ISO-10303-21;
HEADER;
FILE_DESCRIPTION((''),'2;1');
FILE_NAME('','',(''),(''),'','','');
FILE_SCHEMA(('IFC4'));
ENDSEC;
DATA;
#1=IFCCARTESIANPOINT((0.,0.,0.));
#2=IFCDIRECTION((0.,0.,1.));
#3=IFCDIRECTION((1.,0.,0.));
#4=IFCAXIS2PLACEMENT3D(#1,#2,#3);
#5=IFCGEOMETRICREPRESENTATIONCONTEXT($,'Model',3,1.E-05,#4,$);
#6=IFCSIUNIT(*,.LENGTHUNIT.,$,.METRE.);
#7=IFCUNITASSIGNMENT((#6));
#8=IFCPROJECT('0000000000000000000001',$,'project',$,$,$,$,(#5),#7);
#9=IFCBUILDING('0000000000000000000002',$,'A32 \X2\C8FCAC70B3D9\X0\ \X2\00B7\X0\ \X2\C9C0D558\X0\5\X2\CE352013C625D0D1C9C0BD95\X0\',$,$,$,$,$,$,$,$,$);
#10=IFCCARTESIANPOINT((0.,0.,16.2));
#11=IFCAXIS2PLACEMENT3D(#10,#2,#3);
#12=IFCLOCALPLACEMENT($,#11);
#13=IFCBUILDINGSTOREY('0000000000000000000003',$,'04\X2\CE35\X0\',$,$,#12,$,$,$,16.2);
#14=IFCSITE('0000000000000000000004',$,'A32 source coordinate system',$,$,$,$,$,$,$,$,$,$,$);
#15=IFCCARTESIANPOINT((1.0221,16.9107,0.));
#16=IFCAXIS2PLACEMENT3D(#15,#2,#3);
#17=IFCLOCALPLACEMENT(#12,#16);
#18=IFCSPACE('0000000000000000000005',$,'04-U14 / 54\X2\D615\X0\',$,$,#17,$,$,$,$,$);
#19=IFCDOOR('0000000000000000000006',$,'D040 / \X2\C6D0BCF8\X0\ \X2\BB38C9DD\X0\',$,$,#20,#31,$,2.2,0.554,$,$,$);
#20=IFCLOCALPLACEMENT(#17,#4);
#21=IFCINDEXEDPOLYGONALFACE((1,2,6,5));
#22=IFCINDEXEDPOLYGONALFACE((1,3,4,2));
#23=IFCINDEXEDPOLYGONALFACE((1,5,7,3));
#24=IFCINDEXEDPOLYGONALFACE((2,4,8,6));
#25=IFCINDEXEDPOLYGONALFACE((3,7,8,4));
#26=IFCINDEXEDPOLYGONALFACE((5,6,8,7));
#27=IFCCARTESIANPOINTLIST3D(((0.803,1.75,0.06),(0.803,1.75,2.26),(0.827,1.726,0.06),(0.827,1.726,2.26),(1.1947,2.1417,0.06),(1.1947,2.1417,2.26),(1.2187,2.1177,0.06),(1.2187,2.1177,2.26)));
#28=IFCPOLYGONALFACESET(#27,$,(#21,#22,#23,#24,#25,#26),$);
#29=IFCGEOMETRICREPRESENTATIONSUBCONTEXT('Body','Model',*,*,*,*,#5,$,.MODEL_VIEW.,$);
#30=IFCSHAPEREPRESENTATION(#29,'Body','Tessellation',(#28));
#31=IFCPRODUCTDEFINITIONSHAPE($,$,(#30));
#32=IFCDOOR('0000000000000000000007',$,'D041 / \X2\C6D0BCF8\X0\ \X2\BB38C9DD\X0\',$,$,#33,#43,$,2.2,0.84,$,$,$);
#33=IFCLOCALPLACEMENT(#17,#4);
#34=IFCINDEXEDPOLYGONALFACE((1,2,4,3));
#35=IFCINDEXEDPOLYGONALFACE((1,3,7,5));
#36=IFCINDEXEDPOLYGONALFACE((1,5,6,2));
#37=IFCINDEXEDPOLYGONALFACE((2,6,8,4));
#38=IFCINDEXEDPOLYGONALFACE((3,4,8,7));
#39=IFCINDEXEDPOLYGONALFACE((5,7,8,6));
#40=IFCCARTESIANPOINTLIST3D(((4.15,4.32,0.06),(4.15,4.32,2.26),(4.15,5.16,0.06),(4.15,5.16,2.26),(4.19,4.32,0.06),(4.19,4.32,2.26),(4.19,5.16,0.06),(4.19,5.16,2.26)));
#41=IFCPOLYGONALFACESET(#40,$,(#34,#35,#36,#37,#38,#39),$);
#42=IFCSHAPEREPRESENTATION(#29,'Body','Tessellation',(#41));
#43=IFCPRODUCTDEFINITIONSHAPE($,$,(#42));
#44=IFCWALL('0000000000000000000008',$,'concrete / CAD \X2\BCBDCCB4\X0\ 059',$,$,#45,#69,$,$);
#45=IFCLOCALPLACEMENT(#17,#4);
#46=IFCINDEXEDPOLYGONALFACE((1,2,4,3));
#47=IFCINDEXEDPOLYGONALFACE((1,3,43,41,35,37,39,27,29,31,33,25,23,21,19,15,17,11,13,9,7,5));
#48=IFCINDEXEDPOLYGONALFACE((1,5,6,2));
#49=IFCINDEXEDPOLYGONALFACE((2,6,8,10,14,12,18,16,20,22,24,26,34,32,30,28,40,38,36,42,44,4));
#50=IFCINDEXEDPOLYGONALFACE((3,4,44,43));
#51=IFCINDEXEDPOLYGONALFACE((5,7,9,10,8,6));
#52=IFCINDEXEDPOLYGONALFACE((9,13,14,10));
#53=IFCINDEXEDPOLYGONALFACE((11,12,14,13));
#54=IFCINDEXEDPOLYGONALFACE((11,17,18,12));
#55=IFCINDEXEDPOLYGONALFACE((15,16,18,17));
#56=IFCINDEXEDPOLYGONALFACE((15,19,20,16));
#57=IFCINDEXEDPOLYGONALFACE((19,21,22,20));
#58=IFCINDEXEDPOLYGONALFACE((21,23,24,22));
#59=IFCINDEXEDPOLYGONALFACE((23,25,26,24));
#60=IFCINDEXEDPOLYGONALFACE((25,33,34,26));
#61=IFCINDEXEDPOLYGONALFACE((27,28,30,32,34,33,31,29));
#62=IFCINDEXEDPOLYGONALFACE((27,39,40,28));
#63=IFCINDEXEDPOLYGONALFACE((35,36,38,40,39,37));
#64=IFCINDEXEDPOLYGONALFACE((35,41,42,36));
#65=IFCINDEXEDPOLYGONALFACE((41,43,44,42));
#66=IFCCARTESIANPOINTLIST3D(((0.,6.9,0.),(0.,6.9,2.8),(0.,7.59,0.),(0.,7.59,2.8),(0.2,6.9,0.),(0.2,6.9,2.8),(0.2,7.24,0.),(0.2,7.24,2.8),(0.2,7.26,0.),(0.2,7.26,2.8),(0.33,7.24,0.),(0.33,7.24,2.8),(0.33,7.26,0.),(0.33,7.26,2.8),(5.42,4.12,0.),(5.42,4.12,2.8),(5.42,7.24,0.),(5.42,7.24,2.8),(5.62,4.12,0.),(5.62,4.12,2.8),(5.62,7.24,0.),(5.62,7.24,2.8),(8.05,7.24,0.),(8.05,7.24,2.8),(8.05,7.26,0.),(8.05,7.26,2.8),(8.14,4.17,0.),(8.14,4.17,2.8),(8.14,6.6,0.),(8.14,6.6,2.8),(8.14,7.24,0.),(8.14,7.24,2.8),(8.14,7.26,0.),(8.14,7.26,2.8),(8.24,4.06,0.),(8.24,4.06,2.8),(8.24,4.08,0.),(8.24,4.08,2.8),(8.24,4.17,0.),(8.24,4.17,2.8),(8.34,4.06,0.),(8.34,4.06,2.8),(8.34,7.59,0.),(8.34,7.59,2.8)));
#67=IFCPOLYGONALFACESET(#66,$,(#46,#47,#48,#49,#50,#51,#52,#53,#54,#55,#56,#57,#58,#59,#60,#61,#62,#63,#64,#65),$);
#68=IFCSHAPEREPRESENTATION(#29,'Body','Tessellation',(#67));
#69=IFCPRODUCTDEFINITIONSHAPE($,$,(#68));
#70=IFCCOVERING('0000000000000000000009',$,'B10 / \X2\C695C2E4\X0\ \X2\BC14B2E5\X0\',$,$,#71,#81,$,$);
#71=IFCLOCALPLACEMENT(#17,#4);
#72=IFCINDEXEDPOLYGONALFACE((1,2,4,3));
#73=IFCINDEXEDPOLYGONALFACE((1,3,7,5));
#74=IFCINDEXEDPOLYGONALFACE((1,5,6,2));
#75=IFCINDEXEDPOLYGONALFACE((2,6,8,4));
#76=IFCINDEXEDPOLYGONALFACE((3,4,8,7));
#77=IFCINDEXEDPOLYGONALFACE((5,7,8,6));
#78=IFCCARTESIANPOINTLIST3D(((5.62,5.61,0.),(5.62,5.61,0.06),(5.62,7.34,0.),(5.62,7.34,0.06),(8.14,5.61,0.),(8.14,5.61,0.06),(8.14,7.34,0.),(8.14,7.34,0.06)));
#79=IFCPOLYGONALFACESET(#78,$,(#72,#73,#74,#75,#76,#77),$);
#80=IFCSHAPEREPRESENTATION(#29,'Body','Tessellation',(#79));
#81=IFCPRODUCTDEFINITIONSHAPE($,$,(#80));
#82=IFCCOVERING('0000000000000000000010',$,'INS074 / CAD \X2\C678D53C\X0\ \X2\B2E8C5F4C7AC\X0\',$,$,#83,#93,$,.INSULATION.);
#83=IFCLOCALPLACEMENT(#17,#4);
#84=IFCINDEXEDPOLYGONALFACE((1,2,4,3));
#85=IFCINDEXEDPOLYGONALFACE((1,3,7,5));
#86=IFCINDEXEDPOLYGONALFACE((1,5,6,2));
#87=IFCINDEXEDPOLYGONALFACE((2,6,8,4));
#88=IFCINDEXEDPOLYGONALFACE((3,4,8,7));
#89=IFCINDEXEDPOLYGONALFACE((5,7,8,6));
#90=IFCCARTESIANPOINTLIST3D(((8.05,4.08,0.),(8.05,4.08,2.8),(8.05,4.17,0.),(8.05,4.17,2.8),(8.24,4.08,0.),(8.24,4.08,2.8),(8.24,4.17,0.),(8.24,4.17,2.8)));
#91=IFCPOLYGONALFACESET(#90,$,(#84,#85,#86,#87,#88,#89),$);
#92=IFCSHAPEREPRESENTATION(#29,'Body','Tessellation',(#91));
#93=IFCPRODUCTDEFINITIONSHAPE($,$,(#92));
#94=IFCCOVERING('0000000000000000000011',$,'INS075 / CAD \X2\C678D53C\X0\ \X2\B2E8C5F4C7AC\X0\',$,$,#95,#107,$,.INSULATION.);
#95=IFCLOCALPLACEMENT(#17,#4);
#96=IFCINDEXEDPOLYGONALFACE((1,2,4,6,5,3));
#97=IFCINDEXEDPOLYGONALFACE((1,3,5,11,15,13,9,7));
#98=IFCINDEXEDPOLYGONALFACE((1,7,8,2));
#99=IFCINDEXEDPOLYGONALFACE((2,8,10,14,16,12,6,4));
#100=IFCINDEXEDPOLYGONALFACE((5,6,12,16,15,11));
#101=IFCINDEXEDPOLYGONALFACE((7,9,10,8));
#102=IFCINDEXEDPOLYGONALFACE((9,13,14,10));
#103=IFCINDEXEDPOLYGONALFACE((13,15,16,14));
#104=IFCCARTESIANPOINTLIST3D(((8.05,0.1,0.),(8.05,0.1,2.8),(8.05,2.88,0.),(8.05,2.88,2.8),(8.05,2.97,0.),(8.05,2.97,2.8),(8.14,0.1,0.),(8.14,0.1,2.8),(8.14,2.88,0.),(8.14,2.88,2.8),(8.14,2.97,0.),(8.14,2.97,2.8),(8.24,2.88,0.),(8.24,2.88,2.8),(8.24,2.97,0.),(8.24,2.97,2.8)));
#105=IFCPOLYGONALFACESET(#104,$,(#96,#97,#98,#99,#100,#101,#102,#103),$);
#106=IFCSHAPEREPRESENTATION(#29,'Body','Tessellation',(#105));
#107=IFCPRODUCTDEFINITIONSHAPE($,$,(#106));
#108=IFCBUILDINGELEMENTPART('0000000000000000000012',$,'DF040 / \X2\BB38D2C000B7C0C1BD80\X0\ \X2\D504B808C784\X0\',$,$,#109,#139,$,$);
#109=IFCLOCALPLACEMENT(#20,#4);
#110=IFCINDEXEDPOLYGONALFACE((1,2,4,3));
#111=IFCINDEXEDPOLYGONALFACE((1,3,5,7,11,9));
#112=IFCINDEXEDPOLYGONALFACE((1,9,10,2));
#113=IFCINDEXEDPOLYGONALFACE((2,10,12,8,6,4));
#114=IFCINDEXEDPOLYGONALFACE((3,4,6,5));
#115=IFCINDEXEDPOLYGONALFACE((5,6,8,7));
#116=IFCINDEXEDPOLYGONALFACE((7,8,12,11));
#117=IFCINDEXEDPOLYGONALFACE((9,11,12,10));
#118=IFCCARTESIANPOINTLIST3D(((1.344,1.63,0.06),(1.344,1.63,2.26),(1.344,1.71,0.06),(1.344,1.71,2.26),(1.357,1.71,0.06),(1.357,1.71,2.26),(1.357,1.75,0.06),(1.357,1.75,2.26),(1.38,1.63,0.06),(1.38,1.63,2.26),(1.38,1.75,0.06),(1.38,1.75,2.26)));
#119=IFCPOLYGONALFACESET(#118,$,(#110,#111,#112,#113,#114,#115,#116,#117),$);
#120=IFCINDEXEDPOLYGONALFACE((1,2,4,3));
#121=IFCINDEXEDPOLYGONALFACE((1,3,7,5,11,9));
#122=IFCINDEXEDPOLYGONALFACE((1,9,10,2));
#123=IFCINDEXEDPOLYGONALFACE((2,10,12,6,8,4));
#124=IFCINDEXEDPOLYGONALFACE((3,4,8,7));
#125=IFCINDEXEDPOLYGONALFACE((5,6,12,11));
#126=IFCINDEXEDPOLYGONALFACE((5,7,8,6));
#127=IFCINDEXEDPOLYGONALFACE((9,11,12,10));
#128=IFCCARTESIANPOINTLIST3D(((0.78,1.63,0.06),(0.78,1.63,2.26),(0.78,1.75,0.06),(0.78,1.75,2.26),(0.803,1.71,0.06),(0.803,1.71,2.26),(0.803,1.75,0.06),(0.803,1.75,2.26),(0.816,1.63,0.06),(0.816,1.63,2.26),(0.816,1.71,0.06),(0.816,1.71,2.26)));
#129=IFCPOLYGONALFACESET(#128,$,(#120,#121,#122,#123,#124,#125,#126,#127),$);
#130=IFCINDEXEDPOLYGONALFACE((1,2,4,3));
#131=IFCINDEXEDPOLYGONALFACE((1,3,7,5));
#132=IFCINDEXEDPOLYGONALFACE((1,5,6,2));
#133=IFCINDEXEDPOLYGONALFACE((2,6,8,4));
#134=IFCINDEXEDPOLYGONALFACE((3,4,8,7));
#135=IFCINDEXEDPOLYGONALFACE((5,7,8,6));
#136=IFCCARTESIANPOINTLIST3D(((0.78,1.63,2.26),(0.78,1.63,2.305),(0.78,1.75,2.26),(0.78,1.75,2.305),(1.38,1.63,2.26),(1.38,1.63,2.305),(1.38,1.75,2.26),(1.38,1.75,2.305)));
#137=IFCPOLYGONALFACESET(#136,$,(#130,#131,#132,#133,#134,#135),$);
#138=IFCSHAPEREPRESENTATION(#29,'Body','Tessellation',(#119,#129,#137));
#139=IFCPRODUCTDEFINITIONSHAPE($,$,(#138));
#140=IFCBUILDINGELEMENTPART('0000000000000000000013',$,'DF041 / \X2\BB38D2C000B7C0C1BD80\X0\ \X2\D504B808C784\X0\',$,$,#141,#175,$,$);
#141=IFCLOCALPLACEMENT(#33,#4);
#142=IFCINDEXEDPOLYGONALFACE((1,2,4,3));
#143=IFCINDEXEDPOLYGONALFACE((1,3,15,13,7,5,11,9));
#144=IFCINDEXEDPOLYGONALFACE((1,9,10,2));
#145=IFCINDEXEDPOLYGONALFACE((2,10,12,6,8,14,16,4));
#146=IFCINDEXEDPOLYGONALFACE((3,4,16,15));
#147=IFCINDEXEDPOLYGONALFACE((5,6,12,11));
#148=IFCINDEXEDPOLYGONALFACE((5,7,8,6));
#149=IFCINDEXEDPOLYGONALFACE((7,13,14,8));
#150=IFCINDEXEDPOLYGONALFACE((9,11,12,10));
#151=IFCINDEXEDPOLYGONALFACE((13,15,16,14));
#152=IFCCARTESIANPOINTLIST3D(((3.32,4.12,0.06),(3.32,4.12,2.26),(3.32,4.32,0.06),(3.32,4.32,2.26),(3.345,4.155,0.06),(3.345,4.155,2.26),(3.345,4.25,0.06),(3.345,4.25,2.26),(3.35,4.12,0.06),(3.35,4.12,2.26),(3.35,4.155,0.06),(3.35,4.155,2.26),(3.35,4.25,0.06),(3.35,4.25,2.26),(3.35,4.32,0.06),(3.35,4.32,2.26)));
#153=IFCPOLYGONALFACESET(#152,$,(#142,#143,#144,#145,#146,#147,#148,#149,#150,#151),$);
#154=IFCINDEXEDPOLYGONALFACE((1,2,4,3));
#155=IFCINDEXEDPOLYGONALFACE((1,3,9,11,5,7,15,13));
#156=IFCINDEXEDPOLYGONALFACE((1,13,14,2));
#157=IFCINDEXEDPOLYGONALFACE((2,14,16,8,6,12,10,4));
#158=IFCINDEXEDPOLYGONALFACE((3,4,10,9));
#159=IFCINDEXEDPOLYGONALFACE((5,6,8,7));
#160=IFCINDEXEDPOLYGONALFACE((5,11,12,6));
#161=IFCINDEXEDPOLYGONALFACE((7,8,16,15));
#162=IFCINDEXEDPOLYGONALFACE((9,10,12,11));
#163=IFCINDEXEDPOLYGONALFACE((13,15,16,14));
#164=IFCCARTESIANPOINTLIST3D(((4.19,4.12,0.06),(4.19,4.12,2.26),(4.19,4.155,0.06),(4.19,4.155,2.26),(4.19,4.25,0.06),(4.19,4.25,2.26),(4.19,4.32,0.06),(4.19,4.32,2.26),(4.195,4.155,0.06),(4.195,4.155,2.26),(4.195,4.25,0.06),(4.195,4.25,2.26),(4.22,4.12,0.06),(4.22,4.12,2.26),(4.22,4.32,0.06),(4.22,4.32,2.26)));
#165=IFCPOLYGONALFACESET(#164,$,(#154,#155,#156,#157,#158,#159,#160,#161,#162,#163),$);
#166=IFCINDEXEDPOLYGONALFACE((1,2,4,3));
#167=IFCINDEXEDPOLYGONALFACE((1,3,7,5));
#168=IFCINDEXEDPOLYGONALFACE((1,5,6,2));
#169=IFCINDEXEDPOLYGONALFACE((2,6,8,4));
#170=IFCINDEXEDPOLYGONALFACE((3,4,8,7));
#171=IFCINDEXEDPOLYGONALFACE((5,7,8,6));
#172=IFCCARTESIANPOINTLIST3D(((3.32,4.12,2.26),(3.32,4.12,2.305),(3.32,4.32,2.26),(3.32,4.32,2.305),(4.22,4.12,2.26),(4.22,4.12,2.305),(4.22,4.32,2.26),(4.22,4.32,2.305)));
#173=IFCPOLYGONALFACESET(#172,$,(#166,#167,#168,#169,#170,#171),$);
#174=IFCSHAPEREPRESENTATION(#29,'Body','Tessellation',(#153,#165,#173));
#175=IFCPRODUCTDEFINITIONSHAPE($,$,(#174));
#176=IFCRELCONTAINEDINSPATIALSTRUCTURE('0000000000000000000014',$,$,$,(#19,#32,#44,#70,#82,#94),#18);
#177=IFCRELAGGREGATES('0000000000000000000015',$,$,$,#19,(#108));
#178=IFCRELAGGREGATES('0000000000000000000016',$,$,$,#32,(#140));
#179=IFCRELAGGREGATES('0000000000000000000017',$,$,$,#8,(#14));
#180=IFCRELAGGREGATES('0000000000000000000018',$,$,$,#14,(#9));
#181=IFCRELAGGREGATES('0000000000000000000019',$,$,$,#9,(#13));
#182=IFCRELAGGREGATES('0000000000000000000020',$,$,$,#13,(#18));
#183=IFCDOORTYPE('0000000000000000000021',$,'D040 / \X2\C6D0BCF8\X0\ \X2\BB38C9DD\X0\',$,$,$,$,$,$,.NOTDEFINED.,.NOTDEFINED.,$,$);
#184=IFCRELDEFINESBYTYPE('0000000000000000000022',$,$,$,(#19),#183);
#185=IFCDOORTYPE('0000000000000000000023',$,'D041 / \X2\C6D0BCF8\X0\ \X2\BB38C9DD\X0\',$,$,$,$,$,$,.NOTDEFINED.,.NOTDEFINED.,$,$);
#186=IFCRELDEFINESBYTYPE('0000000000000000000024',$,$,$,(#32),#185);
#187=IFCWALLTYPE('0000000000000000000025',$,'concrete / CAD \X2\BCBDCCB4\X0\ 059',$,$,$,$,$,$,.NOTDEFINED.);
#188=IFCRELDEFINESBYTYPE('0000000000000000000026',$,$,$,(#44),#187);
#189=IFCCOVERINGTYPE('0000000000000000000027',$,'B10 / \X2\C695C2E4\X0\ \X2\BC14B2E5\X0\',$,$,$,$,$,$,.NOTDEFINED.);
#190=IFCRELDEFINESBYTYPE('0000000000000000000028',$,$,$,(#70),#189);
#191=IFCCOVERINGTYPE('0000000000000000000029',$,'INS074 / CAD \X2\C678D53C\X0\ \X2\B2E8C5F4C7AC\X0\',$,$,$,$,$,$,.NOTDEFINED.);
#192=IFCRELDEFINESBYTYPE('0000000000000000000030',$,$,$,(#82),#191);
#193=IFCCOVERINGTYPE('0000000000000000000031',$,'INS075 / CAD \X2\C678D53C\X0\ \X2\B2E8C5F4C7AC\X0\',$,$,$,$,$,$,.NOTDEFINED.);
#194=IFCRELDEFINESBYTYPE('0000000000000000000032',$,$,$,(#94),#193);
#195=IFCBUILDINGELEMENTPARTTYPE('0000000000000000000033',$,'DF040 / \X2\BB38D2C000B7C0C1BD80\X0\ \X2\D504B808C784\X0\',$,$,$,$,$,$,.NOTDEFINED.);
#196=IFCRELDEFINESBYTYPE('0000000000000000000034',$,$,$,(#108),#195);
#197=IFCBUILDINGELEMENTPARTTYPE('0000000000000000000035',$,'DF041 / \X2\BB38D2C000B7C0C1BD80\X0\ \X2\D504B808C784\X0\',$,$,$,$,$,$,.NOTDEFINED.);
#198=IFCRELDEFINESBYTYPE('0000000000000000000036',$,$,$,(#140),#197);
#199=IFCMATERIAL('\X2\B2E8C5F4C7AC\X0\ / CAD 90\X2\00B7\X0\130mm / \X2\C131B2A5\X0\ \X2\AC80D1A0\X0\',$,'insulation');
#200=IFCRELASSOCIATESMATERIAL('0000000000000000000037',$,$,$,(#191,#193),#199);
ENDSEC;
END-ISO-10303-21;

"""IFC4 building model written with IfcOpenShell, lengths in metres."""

from ifc_helpers import new_model, si_unit, frame, origin, origin_with_axes, place, context, subcontext, project, spatial, polyline, outline, extrude, source, transform, mapped, material, type_object, type_shapes, element, aggregate, save


model = new_model("IFC4")

# Units and contexts
model_context = context("Model", 3, precision=1e-05, world=origin_with_axes())
body_context = subcontext(model_context, "Body", "Model", "MODEL_VIEW")
ifc_project = project(units=[si_unit("LENGTHUNIT", "METRE")], contexts=[model_context])

# Site, building, storey, space
storey_placement = place(None, frame((0.0, 0.0, 16.2), z_axis=(0.0, 0.0, 1.0), x_axis=(1.0, 0.0, 0.0)))
space_1_placement = place(storey_placement, frame((1.0221, 16.9107, 0.0), z_axis=(0.0, 0.0, 1.0), x_axis=(1.0, 0.0, 0.0)))
site = spatial("IfcSite", under=ifc_project, Name="A32 source coordinate system")
building = spatial("IfcBuilding", under=site, Name="A32 주거동 · 지하5층–옥탑지붕")
storey = spatial("IfcBuildingStorey", under=building, at=storey_placement, Name="04층", Elevation=16.2)
space_1 = spatial("IfcSpace", under=storey, at=space_1_placement, Name="04-U14 / 54형")

# Doors
door_type_1 = type_object("IfcDoorType", Name="D040 / 원본 문짝", OperationType="NOTDEFINED", PredefinedType="NOTDEFINED")
shared_shape_1 = source(origin(), body_context, "Body", "SweptSolid", [
    extrude(outline(polyline([(0.803, 1.75), (1.1947, 2.1417), (1.2187, 2.1177), (0.827, 1.726), (0.803, 1.75)])), frame((0.0, 0.0, 0.06)), (0.0, 0.0, 1.0), 2.2),
])
type_shapes(door_type_1, [shared_shape_1])
door_1_placement = place(space_1_placement, origin_with_axes())
door_1 = element("IfcDoor", 1, at=door_1_placement, inside=space_1, type_object=door_type_1, Name="D040 / 원본 문짝", OverallHeight=2.2, OverallWidth=0.554, context=body_context, shape_type="MappedRepresentation", body=[
    mapped(shared_shape_1, transform((0.0, 0.0, 0.0), scale=1.0)),
])
door_type_2 = type_object("IfcDoorType", Name="D041 / 원본 문짝", OperationType="NOTDEFINED", PredefinedType="NOTDEFINED")
shared_shape_2 = source(origin(), body_context, "Body", "SweptSolid", [
    extrude(outline(polyline([(4.15, 5.16), (4.19, 5.16), (4.19, 4.32), (4.15, 4.32), (4.15, 5.16)])), frame((0.0, 0.0, 0.06)), (0.0, 0.0, 1.0), 2.2),
])
type_shapes(door_type_2, [shared_shape_2])
door_2_placement = place(space_1_placement, origin_with_axes())
door_2 = element("IfcDoor", 2, at=door_2_placement, inside=space_1, type_object=door_type_2, Name="D041 / 원본 문짝", OverallHeight=2.2, OverallWidth=0.84, context=body_context, shape_type="MappedRepresentation", body=[
    mapped(shared_shape_2, transform((0.0, 0.0, 0.0), scale=1.0)),
])

# Wall
wall_type = type_object("IfcWallType", Name="concrete / CAD 벽체 059", PredefinedType="NOTDEFINED")
shared_shape_3 = source(origin(), body_context, "Body", "SweptSolid", [
    extrude(outline(polyline([(8.05, 7.26), (8.05, 7.24), (5.62, 7.24), (5.62, 4.12), (5.42, 4.12), (5.42, 7.24), (0.33, 7.24), (0.33, 7.26), (0.2, 7.26), (0.2, 7.24), (0.2, 6.9), (0.0, 6.9), (0.0, 7.59), (8.34, 7.59), (8.34, 4.06), (8.24, 4.06), (8.24, 4.08), (8.24, 4.17), (8.14, 4.17), (8.14, 6.6), (8.14, 7.24), (8.14, 7.26), (8.05, 7.26)])), origin(), (0.0, 0.0, 1.0), 2.8),
])
type_shapes(wall_type, [shared_shape_3])
wall_placement = place(space_1_placement, origin_with_axes())
element("IfcWall", 3, at=wall_placement, inside=space_1, type_object=wall_type, Name="concrete / CAD 벽체 059", context=body_context, shape_type="MappedRepresentation", body=[
    mapped(shared_shape_3, transform((0.0, 0.0, 0.0), scale=1.0)),
])

# Coverings
covering_type_1 = type_object("IfcCoveringType", Name="B10 / 욕실 바닥", PredefinedType="NOTDEFINED")
shared_shape_4 = source(origin(), body_context, "Body", "SweptSolid", [
    extrude(outline(polyline([(8.14, 5.61), (5.62, 5.61), (5.62, 7.34), (8.14, 7.34), (8.14, 5.61)])), origin(), (0.0, 0.0, 1.0), 0.06),
])
type_shapes(covering_type_1, [shared_shape_4])
covering_1_placement = place(space_1_placement, origin_with_axes())
element("IfcCovering", 4, at=covering_1_placement, inside=space_1, type_object=covering_type_1, Name="B10 / 욕실 바닥", context=body_context, shape_type="MappedRepresentation", body=[
    mapped(shared_shape_4, transform((0.0, 0.0, 0.0), scale=1.0)),
])
ifc_material = material(Name="단열재 / CAD 90·130mm / 성능 검토", Category="insulation")
covering_type_2 = type_object("IfcCoveringType", Name="INS074 / CAD 외피 단열재", PredefinedType="NOTDEFINED", material=ifc_material)
shared_shape_5 = source(origin(), body_context, "Body", "SweptSolid", [
    extrude(outline(polyline([(8.05, 4.08), (8.05, 4.17), (8.24, 4.17), (8.24, 4.08), (8.05, 4.08)])), origin(), (0.0, 0.0, 1.0), 2.8),
])
type_shapes(covering_type_2, [shared_shape_5])
covering_2_placement = place(space_1_placement, origin_with_axes())
element("IfcCovering", 5, at=covering_2_placement, inside=space_1, type_object=covering_type_2, Name="INS074 / CAD 외피 단열재", PredefinedType="INSULATION", context=body_context, shape_type="MappedRepresentation", body=[
    mapped(shared_shape_5, transform((0.0, 0.0, 0.0), scale=1.0)),
])
covering_type_3 = type_object("IfcCoveringType", Name="INS075 / CAD 외피 단열재", PredefinedType="NOTDEFINED", material=ifc_material)
shared_shape_6 = source(origin(), body_context, "Body", "SweptSolid", [
    extrude(outline(polyline([(8.24, 2.88), (8.14, 2.88), (8.14, 0.1), (8.05, 0.1), (8.05, 2.88), (8.05, 2.97), (8.14, 2.97), (8.24, 2.97), (8.24, 2.88)])), origin(), (0.0, 0.0, 1.0), 2.8),
])
type_shapes(covering_type_3, [shared_shape_6])
covering_3_placement = place(space_1_placement, origin_with_axes())
element("IfcCovering", 6, at=covering_3_placement, inside=space_1, type_object=covering_type_3, Name="INS075 / CAD 외피 단열재", PredefinedType="INSULATION", context=body_context, shape_type="MappedRepresentation", body=[
    mapped(shared_shape_6, transform((0.0, 0.0, 0.0), scale=1.0)),
])

# Building element parts
building_element_part_type_1 = type_object("IfcBuildingElementPartType", Name="DF040 / 문틀·상부 프레임", PredefinedType="NOTDEFINED")
shared_shape_7 = source(origin(), body_context, "Body", "SweptSolid", [
    extrude(outline(polyline([(1.344, 1.63), (1.344, 1.71), (1.357, 1.71), (1.357, 1.75), (1.38, 1.75), (1.38, 1.63), (1.344, 1.63)])), frame((0.0, 0.0, 0.06)), (0.0, 0.0, 1.0), 2.2),
    extrude(outline(polyline([(0.78, 1.75), (0.803, 1.75), (0.803, 1.71), (0.816, 1.71), (0.816, 1.63), (0.78, 1.63), (0.78, 1.75)])), frame((0.0, 0.0, 0.06)), (0.0, 0.0, 1.0), 2.2),
    extrude(outline(polyline([(0.78, 1.63), (0.78, 1.75), (1.38, 1.75), (1.38, 1.63), (0.78, 1.63)])), frame((0.0, 0.0, 2.26)), (0.0, 0.0, 1.0), 0.045),
])
type_shapes(building_element_part_type_1, [shared_shape_7])
building_element_part_1_placement = place(door_1_placement, origin_with_axes())
building_element_part_1 = element("IfcBuildingElementPart", 7, at=building_element_part_1_placement, type_object=building_element_part_type_1, Name="DF040 / 문틀·상부 프레임", context=body_context, shape_type="MappedRepresentation", body=[
    mapped(shared_shape_7, transform((0.0, 0.0, 0.0), scale=1.0)),
])
aggregate(door_1, [building_element_part_1])
building_element_part_type_2 = type_object("IfcBuildingElementPartType", Name="DF041 / 문틀·상부 프레임", PredefinedType="NOTDEFINED")
shared_shape_8 = source(origin(), body_context, "Body", "SweptSolid", [
    extrude(outline(polyline([(3.35, 4.32), (3.35, 4.25), (3.345, 4.25), (3.345, 4.155), (3.35, 4.155), (3.35, 4.12), (3.32, 4.12), (3.32, 4.32), (3.35, 4.32)])), frame((0.0, 0.0, 0.06)), (0.0, 0.0, 1.0), 2.2),
    extrude(outline(polyline([(4.22, 4.12), (4.19, 4.12), (4.19, 4.155), (4.195, 4.155), (4.195, 4.25), (4.19, 4.25), (4.19, 4.32), (4.22, 4.32), (4.22, 4.12)])), frame((0.0, 0.0, 0.06)), (0.0, 0.0, 1.0), 2.2),
    extrude(outline(polyline([(3.32, 4.12), (3.32, 4.32), (4.22, 4.32), (4.22, 4.12), (3.32, 4.12)])), frame((0.0, 0.0, 2.26)), (0.0, 0.0, 1.0), 0.045),
])
type_shapes(building_element_part_type_2, [shared_shape_8])
building_element_part_2_placement = place(door_2_placement, origin_with_axes())
building_element_part_2 = element("IfcBuildingElementPart", 8, at=building_element_part_2_placement, type_object=building_element_part_type_2, Name="DF041 / 문틀·상부 프레임", context=body_context, shape_type="MappedRepresentation", body=[
    mapped(shared_shape_8, transform((0.0, 0.0, 0.0), scale=1.0)),
])
aggregate(door_2, [building_element_part_2])

save(model, "model.ifc")
